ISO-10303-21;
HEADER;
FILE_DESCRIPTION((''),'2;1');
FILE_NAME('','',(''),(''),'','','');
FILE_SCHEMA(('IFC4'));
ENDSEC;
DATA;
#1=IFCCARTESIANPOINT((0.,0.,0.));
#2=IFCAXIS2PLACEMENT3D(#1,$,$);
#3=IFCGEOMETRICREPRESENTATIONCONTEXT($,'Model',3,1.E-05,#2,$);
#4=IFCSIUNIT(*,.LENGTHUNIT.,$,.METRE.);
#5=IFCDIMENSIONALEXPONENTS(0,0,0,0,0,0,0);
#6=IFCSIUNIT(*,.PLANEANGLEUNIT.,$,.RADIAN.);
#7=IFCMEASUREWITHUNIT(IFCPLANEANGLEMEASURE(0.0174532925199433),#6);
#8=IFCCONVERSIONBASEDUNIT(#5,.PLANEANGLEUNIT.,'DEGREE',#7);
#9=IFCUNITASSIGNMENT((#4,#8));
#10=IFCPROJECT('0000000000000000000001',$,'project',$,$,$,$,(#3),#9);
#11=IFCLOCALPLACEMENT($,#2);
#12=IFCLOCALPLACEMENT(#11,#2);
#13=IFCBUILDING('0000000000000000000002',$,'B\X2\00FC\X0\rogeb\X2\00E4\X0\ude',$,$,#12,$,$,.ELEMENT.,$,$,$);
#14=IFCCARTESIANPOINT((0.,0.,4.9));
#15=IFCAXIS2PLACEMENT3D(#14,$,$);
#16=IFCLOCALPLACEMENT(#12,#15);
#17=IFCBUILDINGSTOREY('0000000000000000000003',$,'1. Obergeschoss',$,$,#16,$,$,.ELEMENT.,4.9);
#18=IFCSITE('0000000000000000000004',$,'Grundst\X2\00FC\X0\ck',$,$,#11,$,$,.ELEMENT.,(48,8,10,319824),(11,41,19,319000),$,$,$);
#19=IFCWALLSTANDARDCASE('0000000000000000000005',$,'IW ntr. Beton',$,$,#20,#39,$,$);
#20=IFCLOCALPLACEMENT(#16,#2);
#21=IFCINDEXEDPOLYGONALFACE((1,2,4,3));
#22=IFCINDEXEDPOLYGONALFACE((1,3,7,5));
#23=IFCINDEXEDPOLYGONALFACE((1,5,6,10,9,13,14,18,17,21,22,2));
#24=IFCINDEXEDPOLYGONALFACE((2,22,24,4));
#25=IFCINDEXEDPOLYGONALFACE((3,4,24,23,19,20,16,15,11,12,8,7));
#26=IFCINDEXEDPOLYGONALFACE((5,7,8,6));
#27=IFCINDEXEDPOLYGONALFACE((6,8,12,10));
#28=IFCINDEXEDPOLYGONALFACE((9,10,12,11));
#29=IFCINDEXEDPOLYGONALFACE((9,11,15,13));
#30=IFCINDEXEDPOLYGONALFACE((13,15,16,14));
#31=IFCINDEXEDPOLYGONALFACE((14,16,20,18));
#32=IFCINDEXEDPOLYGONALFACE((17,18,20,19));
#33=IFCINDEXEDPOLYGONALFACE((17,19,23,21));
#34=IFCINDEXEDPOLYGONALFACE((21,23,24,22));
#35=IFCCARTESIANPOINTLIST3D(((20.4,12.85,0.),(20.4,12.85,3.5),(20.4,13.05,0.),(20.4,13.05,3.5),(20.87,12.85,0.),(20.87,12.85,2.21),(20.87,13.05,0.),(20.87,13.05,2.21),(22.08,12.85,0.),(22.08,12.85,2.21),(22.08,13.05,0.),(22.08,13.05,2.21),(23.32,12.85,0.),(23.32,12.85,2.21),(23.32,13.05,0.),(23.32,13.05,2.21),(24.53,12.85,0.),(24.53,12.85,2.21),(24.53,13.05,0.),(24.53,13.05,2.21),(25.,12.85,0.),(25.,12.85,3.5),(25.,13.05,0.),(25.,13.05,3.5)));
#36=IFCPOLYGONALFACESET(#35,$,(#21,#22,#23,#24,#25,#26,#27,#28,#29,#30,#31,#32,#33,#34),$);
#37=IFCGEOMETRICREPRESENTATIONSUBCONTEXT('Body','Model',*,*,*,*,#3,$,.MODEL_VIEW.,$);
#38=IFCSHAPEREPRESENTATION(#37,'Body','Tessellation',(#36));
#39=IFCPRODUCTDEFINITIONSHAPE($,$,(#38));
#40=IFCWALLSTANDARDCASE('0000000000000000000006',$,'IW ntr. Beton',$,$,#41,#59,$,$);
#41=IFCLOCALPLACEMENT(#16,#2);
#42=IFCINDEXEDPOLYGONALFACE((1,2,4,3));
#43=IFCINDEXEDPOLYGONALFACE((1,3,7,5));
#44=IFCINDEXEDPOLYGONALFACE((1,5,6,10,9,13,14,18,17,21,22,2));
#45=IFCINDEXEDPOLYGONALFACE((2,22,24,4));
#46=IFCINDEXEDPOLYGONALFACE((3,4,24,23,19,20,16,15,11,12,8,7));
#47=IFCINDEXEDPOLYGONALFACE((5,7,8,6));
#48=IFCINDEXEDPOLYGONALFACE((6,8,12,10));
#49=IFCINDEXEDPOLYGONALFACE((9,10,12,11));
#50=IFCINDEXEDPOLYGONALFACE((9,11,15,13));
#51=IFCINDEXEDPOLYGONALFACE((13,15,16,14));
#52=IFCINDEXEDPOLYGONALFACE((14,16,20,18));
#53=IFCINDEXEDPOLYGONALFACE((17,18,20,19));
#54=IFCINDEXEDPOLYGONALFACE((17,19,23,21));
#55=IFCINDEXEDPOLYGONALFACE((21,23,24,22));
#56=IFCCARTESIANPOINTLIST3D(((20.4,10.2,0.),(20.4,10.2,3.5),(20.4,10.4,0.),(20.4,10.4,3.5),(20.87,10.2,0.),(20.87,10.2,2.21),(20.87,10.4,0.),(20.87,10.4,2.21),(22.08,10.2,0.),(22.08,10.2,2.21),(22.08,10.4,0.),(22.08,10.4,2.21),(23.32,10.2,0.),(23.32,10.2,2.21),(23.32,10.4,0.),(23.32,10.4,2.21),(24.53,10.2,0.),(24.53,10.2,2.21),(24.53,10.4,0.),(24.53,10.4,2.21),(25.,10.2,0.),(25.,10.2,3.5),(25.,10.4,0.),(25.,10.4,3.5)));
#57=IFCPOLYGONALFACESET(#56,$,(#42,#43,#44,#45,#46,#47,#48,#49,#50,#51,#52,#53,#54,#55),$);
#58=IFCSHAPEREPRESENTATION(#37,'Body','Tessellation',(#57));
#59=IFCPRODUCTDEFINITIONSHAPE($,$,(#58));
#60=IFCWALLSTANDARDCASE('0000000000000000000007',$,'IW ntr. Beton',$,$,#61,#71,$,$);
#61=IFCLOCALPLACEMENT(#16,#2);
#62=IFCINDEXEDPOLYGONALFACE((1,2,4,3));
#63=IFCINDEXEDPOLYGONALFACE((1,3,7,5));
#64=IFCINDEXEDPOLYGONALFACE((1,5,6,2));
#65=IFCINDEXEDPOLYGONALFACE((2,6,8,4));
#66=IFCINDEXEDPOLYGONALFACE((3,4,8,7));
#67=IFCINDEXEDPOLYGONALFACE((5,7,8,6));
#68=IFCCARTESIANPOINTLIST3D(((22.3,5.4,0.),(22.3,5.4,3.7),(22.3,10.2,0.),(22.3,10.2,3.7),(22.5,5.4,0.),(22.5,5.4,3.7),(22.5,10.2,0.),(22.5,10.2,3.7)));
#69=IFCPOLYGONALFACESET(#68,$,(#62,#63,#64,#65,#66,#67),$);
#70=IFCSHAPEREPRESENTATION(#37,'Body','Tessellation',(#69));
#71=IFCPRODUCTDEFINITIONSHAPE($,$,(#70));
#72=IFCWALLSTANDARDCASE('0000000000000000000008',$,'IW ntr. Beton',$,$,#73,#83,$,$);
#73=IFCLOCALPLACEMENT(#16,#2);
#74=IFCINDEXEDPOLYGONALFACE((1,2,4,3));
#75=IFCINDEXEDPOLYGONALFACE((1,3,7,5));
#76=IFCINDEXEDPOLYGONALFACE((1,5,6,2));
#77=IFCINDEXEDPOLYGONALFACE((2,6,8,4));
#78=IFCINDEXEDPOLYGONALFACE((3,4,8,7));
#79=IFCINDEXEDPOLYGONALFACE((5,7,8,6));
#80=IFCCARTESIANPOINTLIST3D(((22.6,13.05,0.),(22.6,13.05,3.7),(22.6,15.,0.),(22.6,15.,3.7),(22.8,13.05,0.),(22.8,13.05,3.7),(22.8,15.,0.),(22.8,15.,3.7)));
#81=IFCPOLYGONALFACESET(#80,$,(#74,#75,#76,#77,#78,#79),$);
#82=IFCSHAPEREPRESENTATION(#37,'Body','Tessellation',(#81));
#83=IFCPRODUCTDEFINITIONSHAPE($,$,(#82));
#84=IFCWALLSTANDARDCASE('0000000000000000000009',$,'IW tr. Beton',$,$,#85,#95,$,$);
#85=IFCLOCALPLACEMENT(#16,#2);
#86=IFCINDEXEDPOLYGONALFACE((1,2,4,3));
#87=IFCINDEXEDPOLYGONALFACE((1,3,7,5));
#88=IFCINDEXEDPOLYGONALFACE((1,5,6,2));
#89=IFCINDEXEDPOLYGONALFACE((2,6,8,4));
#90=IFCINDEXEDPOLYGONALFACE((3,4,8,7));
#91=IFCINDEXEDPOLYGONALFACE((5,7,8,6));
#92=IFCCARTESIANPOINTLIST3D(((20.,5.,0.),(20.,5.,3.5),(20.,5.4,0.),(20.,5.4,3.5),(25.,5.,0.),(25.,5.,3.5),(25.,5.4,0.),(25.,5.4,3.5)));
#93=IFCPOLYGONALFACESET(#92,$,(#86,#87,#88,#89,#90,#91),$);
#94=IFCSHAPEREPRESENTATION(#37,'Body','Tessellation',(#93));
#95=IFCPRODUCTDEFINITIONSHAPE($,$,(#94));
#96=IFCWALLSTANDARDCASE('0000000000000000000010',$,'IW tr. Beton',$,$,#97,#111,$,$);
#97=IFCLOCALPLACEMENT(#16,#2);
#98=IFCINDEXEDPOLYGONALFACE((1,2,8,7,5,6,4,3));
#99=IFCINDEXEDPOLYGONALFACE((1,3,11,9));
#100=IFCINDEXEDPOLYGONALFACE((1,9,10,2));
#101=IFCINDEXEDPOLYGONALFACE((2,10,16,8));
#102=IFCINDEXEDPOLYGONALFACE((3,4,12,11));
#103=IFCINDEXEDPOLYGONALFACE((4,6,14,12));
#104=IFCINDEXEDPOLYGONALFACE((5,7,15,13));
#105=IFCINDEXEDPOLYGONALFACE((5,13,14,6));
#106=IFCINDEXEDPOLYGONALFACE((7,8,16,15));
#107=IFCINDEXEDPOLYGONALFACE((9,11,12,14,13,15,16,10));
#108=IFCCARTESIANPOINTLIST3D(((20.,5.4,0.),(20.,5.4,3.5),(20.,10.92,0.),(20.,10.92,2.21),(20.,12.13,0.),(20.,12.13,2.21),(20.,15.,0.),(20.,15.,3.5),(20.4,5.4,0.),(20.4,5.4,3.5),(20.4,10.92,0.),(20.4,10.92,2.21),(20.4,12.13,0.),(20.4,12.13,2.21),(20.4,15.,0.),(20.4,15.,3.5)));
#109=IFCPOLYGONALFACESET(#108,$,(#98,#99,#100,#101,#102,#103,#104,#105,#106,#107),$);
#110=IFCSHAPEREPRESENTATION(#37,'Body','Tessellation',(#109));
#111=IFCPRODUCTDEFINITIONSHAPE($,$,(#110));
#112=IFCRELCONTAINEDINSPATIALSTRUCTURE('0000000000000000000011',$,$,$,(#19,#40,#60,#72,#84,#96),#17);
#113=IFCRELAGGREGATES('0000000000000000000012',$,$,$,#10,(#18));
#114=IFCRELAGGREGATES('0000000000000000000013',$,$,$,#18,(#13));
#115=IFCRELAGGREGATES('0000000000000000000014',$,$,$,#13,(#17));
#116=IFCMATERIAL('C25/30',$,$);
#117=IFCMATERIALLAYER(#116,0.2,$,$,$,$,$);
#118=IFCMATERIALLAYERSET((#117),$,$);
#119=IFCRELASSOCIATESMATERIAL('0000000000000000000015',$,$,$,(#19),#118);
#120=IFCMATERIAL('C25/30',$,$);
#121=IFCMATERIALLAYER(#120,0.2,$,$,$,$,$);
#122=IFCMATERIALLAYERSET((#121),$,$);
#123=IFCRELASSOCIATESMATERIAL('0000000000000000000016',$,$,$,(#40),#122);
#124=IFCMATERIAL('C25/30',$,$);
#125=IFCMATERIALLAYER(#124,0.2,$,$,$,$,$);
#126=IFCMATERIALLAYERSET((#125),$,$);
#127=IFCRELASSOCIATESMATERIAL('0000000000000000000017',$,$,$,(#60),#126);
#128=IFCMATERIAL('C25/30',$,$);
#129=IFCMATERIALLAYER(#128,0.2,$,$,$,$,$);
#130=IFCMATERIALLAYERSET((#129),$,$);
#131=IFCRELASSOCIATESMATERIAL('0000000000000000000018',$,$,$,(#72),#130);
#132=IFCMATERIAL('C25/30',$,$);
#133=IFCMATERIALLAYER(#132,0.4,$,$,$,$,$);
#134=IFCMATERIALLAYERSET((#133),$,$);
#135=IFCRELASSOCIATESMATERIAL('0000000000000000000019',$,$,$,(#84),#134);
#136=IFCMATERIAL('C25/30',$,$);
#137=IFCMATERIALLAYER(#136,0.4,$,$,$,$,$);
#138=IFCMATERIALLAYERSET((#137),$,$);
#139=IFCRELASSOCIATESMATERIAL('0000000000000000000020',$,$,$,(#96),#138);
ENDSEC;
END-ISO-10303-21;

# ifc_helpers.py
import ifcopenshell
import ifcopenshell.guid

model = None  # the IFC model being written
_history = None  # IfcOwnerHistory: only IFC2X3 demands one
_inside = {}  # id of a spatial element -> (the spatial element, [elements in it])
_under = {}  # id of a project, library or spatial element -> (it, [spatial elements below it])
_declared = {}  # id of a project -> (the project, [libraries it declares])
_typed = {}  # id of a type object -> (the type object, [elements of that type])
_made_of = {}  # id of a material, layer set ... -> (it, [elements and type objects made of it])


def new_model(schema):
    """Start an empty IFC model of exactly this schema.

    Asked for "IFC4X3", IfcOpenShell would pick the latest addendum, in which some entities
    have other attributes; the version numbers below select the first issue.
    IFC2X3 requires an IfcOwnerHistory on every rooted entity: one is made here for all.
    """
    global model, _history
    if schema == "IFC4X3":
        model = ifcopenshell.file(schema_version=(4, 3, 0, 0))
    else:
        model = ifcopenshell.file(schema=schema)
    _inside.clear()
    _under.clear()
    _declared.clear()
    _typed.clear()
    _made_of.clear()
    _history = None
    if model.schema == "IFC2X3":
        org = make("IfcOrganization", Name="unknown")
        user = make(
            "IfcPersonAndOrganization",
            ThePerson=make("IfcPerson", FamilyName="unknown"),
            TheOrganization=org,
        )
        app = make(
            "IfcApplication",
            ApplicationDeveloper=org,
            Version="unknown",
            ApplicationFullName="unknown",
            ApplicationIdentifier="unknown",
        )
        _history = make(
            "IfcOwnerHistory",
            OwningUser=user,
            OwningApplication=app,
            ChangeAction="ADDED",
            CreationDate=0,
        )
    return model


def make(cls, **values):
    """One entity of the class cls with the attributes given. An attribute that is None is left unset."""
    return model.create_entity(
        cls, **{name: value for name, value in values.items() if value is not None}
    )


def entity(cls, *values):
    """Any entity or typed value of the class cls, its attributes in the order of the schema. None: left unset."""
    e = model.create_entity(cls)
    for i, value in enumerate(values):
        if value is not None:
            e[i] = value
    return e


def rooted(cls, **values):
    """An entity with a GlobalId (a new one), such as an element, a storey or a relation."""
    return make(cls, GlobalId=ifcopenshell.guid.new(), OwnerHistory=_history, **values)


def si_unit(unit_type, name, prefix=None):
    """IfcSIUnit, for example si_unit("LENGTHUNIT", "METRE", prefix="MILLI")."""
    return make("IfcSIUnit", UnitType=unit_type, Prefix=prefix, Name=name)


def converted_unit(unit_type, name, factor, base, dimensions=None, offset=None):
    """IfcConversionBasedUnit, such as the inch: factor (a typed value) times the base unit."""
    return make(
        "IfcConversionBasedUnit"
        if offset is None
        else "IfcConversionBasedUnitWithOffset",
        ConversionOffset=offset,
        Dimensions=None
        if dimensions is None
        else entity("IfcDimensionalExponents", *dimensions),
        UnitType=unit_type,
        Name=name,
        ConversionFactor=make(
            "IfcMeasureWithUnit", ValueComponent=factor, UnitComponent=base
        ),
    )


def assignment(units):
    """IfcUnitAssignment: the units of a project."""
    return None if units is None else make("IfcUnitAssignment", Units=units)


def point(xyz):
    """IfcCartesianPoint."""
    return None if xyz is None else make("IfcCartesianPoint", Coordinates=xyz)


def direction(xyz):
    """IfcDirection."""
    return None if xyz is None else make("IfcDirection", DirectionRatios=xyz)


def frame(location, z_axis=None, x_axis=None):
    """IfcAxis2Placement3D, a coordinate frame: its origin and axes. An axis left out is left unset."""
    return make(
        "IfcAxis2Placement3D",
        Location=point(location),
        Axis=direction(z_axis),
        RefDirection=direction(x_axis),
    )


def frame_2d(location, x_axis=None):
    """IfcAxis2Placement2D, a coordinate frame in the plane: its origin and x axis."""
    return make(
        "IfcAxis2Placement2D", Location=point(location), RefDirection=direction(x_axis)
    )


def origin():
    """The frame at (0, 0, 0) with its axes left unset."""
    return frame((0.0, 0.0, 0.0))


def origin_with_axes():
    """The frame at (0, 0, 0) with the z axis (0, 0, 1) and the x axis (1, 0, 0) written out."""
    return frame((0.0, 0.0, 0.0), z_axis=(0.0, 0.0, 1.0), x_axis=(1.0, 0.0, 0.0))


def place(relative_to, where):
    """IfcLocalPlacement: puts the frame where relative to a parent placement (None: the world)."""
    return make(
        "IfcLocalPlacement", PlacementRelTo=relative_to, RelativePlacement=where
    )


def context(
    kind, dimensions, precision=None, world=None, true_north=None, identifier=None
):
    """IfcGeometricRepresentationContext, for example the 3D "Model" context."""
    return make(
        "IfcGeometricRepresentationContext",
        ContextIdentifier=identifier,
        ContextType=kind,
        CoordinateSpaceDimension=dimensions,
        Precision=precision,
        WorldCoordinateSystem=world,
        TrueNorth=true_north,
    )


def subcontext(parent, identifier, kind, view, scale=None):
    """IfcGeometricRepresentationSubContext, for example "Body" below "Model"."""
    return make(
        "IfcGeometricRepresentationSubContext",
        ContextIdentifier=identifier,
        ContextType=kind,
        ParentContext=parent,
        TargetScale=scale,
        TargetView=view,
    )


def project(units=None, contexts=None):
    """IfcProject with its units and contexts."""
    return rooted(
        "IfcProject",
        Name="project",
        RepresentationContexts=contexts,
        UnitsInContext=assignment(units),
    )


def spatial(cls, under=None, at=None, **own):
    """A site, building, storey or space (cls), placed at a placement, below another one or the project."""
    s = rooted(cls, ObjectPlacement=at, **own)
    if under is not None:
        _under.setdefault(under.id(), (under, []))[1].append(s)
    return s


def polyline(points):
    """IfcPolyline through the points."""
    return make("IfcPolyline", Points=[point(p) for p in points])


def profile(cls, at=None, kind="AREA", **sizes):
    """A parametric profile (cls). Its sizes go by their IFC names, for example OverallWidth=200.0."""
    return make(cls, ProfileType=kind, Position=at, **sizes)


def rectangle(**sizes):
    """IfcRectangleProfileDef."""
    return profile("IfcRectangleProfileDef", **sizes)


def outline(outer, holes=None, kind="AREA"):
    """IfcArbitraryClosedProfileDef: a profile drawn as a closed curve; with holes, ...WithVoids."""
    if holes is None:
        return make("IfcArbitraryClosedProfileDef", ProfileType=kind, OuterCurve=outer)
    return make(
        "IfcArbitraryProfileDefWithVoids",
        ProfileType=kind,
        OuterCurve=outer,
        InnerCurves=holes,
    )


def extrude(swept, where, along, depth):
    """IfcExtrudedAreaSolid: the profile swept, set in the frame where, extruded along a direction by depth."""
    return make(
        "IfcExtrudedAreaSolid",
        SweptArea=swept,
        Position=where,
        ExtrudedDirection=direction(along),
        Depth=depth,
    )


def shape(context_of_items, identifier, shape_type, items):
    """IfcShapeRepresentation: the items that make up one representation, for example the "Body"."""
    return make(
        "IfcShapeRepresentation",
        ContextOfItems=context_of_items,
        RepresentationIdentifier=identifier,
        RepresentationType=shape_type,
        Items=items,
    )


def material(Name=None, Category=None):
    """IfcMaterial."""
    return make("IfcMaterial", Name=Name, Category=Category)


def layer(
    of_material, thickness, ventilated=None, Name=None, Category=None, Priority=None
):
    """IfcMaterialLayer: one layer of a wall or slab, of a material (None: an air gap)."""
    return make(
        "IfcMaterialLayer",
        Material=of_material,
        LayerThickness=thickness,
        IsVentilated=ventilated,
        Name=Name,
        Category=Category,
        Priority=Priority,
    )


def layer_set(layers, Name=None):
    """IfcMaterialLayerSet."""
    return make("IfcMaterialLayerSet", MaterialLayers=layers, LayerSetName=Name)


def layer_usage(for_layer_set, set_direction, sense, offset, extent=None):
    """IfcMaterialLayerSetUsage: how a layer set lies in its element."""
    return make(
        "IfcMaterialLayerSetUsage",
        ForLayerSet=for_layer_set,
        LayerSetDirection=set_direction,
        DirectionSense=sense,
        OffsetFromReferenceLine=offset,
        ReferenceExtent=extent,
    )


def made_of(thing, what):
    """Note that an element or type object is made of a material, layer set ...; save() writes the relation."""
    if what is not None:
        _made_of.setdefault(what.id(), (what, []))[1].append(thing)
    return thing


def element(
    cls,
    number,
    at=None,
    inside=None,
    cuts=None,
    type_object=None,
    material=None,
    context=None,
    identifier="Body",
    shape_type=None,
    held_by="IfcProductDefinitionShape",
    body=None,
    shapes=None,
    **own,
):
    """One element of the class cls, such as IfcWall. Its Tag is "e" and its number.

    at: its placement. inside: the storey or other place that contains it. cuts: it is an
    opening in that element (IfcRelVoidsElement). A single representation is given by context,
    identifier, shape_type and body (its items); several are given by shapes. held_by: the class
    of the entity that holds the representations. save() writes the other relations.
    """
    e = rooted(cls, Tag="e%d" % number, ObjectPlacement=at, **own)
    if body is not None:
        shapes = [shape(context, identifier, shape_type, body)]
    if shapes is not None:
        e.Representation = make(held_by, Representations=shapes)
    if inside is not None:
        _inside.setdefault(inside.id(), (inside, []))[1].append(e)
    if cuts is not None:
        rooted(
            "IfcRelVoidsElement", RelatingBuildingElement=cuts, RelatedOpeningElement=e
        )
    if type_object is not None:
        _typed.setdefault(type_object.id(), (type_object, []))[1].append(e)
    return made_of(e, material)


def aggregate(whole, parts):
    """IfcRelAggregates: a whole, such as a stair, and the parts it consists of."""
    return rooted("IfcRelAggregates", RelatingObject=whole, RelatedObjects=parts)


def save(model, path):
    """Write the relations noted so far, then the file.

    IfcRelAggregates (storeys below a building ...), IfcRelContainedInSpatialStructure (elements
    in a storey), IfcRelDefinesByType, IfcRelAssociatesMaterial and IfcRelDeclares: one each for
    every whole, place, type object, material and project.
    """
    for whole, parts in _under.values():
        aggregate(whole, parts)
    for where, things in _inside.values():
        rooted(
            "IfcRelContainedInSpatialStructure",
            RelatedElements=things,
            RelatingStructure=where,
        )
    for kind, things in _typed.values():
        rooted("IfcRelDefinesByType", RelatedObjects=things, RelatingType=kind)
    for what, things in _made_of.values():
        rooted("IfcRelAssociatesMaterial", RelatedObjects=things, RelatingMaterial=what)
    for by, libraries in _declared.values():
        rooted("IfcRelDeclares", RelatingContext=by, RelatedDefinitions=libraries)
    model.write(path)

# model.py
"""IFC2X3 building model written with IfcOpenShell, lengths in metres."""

from ifc_helpers import new_model, entity, si_unit, converted_unit, frame, frame_2d, origin, origin_with_axes, place, context, subcontext, project, spatial, polyline, rectangle, outline, extrude, material, layer, layer_set, layer_usage, element, save


model = new_model("IFC2X3")

# Units and contexts
model_context = context("Model", 3, precision=1e-05, world=origin())
body_context = subcontext(model_context, "Body", "Model", "MODEL_VIEW")
ifc_project = project(units=[si_unit("LENGTHUNIT", "METRE"), converted_unit("PLANEANGLEUNIT", "DEGREE", entity("IfcPlaneAngleMeasure", 0.0174532925199433), si_unit("PLANEANGLEUNIT", "RADIAN"), dimensions=[0, 0, 0, 0, 0, 0, 0])], contexts=[model_context])

# Site, building, storey
site_placement = place(None, origin())
site = spatial("IfcSite", under=ifc_project, at=site_placement, Name="Grundstück", CompositionType="ELEMENT", RefLatitude=(48, 8, 10, 319824), RefLongitude=(11, 41, 19, 319000))
building_placement = place(site_placement, origin())
building = spatial("IfcBuilding", under=site, at=building_placement, Name="Bürogebäude", CompositionType="ELEMENT")
storey_placement = place(building_placement, frame((0.0, 0.0, 4.9)))
storey = spatial("IfcBuildingStorey", under=building, at=storey_placement, Name="1. Obergeschoss", CompositionType="ELEMENT", Elevation=4.9)

# Walls, openings
ifc_material_1 = material(Name="C25/30")
ifc_layer_1 = layer(ifc_material_1, 0.2)
ifc_layer_set_1 = layer_set([ifc_layer_1])
ifc_layer_usage_1 = layer_usage(ifc_layer_set_1, "AXIS2", "POSITIVE", -0.2)
wall_1_placement = place(storey_placement, frame((25.0, 13.05, 0.0), z_axis=(0.0, 0.0, 1.0), x_axis=(-1.0, 0.0, 0.0)))
wall_1 = element("IfcWallStandardCase", 1, at=wall_1_placement, inside=storey, material=ifc_layer_usage_1, Name="IW ntr. Beton", context=body_context, shape_type="SweptSolid", body=[
    extrude(rectangle(XDim=4.6, YDim=0.2, at=frame_2d((2.3, 0.1), x_axis=(1.0, 0.0))), origin_with_axes(), (0.0, 0.0, 1.0), 3.5),
])
opening_1_placement = place(wall_1_placement, frame((4.13, 0.2, 0.0), z_axis=(0.0, -1.0, 0.0), x_axis=(0.0, 0.0, 1.0)))
element("IfcOpeningElement", 2, at=opening_1_placement, cuts=wall_1, ObjectType="Opening", context=body_context, shape_type="SweptSolid", body=[
    extrude(outline(polyline([(0.0, 1.21), (2.21, 1.21), (2.21, 0.0), (0.0, 0.0), (0.0, 1.21)])), origin_with_axes(), (0.0, 0.0, 1.0), 0.2),
])
opening_2_placement = place(wall_1_placement, frame((1.68, 0.2, 0.0), z_axis=(0.0, -1.0, 0.0), x_axis=(0.0, 0.0, 1.0)))
element("IfcOpeningElement", 3, at=opening_2_placement, cuts=wall_1, ObjectType="Opening", context=body_context, shape_type="SweptSolid", body=[
    extrude(outline(polyline([(0.0, 1.21), (2.21, 1.21), (2.21, 0.0), (0.0, 0.0), (0.0, 1.21)])), origin_with_axes(), (0.0, 0.0, 1.0), 0.2),
])
ifc_material_2 = material(Name="C25/30")
ifc_layer_2 = layer(ifc_material_2, 0.2)
ifc_layer_set_2 = layer_set([ifc_layer_2])
ifc_layer_usage_2 = layer_usage(ifc_layer_set_2, "AXIS2", "POSITIVE", -0.2)
wall_2_placement = place(storey_placement, frame((25.0, 10.4, 0.0), z_axis=(0.0, 0.0, 1.0), x_axis=(-1.0, 0.0, 0.0)))
wall_2 = element("IfcWallStandardCase", 4, at=wall_2_placement, inside=storey, material=ifc_layer_usage_2, Name="IW ntr. Beton", context=body_context, shape_type="SweptSolid", body=[
    extrude(rectangle(XDim=4.6, YDim=0.2, at=frame_2d((2.3, 0.1), x_axis=(1.0, 0.0))), origin_with_axes(), (0.0, 0.0, 1.0), 3.5),
])
opening_3_placement = place(wall_2_placement, frame((1.68, 0.2, 0.0), z_axis=(0.0, -1.0, 0.0), x_axis=(0.0, 0.0, 1.0)))
element("IfcOpeningElement", 5, at=opening_3_placement, cuts=wall_2, ObjectType="Opening", context=body_context, shape_type="SweptSolid", body=[
    extrude(outline(polyline([(0.0, 1.21), (2.21, 1.21), (2.21, 0.0), (0.0, 0.0), (0.0, 1.21)])), origin_with_axes(), (0.0, 0.0, 1.0), 0.2),
])
opening_4_placement = place(wall_2_placement, frame((4.13, 0.2, 0.0), z_axis=(0.0, -1.0, 0.0), x_axis=(0.0, 0.0, 1.0)))
element("IfcOpeningElement", 6, at=opening_4_placement, cuts=wall_2, ObjectType="Opening", context=body_context, shape_type="SweptSolid", body=[
    extrude(outline(polyline([(0.0, 1.21), (2.21, 1.21), (2.21, 0.0), (0.0, 0.0), (0.0, 1.21)])), origin_with_axes(), (0.0, 0.0, 1.0), 0.2),
])

# Walls
ifc_material_3 = material(Name="C25/30")
ifc_layer_3 = layer(ifc_material_3, 0.2)
ifc_layer_set_3 = layer_set([ifc_layer_3])
ifc_layer_usage_3 = layer_usage(ifc_layer_set_3, "AXIS2", "POSITIVE", -0.2)
wall_3_placement = place(storey_placement, frame((22.3, 10.2, 0.0), z_axis=(0.0, 0.0, 1.0), x_axis=(0.0, -1.0, 0.0)))
element("IfcWallStandardCase", 7, at=wall_3_placement, inside=storey, material=ifc_layer_usage_3, Name="IW ntr. Beton", context=body_context, shape_type="SweptSolid", body=[
    extrude(rectangle(XDim=4.8, YDim=0.2, at=frame_2d((2.4, 0.1), x_axis=(1.0, 0.0))), origin_with_axes(), (0.0, 0.0, 1.0), 3.7),
])
ifc_material_4 = material(Name="C25/30")
ifc_layer_4 = layer(ifc_material_4, 0.2)
ifc_layer_set_4 = layer_set([ifc_layer_4])
ifc_layer_usage_4 = layer_usage(ifc_layer_set_4, "AXIS2", "POSITIVE", -0.2)
wall_4_placement = place(storey_placement, frame((22.6, 15.0, 0.0), z_axis=(0.0, 0.0, 1.0), x_axis=(0.0, -1.0, 0.0)))
element("IfcWallStandardCase", 8, at=wall_4_placement, inside=storey, material=ifc_layer_usage_4, Name="IW ntr. Beton", context=body_context, shape_type="SweptSolid", body=[
    extrude(rectangle(XDim=1.95, YDim=0.2, at=frame_2d((0.975, 0.1), x_axis=(1.0, 0.0))), origin_with_axes(), (0.0, 0.0, 1.0), 3.7),
])
ifc_material_5 = material(Name="C25/30")
ifc_layer_5 = layer(ifc_material_5, 0.4)
ifc_layer_set_5 = layer_set([ifc_layer_5])
ifc_layer_usage_5 = layer_usage(ifc_layer_set_5, "AXIS2", "POSITIVE", -0.2)
wall_5_placement = place(storey_placement, frame((25.0, 5.4, 0.0), z_axis=(0.0, 0.0, 1.0), x_axis=(-1.0, 0.0, 0.0)))
element("IfcWallStandardCase", 9, at=wall_5_placement, inside=storey, material=ifc_layer_usage_5, Name="IW tr. Beton", context=body_context, shape_type="SweptSolid", body=[
    extrude(rectangle(XDim=5.0, YDim=0.4, at=frame_2d((2.5, 0.2), x_axis=(1.0, 0.0))), origin_with_axes(), (0.0, 0.0, 1.0), 3.5),
])

# Wall, opening
ifc_material_6 = material(Name="C25/30")
ifc_layer_6 = layer(ifc_material_6, 0.4)
ifc_layer_set_6 = layer_set([ifc_layer_6])
ifc_layer_usage_6 = layer_usage(ifc_layer_set_6, "AXIS2", "POSITIVE", -0.2)
wall_6_placement = place(storey_placement, frame((20.4, 5.4, 0.0), z_axis=(0.0, 0.0, 1.0), x_axis=(0.0, 1.0, 0.0)))
wall_6 = element("IfcWallStandardCase", 10, at=wall_6_placement, inside=storey, material=ifc_layer_usage_6, Name="IW tr. Beton", context=body_context, shape_type="SweptSolid", body=[
    extrude(rectangle(XDim=9.6, YDim=0.4, at=frame_2d((4.8, 0.2), x_axis=(1.0, 0.0))), origin_with_axes(), (0.0, 0.0, 1.0), 3.5),
])
opening_5_placement = place(wall_6_placement, frame((5.52, 0.0, 0.0), z_axis=(0.0, 1.0, 0.0), x_axis=(0.0, 0.0, 1.0)))
element("IfcOpeningElement", 11, at=opening_5_placement, cuts=wall_6, ObjectType="Opening", context=body_context, shape_type="SweptSolid", body=[
    extrude(outline(polyline([(0.0, 1.21), (2.21, 1.21), (2.21, 0.0), (0.0, 0.0), (0.0, 1.21)])), origin_with_axes(), (0.0, 0.0, 1.0), 0.4),
])

save(model, "model.ifc")
